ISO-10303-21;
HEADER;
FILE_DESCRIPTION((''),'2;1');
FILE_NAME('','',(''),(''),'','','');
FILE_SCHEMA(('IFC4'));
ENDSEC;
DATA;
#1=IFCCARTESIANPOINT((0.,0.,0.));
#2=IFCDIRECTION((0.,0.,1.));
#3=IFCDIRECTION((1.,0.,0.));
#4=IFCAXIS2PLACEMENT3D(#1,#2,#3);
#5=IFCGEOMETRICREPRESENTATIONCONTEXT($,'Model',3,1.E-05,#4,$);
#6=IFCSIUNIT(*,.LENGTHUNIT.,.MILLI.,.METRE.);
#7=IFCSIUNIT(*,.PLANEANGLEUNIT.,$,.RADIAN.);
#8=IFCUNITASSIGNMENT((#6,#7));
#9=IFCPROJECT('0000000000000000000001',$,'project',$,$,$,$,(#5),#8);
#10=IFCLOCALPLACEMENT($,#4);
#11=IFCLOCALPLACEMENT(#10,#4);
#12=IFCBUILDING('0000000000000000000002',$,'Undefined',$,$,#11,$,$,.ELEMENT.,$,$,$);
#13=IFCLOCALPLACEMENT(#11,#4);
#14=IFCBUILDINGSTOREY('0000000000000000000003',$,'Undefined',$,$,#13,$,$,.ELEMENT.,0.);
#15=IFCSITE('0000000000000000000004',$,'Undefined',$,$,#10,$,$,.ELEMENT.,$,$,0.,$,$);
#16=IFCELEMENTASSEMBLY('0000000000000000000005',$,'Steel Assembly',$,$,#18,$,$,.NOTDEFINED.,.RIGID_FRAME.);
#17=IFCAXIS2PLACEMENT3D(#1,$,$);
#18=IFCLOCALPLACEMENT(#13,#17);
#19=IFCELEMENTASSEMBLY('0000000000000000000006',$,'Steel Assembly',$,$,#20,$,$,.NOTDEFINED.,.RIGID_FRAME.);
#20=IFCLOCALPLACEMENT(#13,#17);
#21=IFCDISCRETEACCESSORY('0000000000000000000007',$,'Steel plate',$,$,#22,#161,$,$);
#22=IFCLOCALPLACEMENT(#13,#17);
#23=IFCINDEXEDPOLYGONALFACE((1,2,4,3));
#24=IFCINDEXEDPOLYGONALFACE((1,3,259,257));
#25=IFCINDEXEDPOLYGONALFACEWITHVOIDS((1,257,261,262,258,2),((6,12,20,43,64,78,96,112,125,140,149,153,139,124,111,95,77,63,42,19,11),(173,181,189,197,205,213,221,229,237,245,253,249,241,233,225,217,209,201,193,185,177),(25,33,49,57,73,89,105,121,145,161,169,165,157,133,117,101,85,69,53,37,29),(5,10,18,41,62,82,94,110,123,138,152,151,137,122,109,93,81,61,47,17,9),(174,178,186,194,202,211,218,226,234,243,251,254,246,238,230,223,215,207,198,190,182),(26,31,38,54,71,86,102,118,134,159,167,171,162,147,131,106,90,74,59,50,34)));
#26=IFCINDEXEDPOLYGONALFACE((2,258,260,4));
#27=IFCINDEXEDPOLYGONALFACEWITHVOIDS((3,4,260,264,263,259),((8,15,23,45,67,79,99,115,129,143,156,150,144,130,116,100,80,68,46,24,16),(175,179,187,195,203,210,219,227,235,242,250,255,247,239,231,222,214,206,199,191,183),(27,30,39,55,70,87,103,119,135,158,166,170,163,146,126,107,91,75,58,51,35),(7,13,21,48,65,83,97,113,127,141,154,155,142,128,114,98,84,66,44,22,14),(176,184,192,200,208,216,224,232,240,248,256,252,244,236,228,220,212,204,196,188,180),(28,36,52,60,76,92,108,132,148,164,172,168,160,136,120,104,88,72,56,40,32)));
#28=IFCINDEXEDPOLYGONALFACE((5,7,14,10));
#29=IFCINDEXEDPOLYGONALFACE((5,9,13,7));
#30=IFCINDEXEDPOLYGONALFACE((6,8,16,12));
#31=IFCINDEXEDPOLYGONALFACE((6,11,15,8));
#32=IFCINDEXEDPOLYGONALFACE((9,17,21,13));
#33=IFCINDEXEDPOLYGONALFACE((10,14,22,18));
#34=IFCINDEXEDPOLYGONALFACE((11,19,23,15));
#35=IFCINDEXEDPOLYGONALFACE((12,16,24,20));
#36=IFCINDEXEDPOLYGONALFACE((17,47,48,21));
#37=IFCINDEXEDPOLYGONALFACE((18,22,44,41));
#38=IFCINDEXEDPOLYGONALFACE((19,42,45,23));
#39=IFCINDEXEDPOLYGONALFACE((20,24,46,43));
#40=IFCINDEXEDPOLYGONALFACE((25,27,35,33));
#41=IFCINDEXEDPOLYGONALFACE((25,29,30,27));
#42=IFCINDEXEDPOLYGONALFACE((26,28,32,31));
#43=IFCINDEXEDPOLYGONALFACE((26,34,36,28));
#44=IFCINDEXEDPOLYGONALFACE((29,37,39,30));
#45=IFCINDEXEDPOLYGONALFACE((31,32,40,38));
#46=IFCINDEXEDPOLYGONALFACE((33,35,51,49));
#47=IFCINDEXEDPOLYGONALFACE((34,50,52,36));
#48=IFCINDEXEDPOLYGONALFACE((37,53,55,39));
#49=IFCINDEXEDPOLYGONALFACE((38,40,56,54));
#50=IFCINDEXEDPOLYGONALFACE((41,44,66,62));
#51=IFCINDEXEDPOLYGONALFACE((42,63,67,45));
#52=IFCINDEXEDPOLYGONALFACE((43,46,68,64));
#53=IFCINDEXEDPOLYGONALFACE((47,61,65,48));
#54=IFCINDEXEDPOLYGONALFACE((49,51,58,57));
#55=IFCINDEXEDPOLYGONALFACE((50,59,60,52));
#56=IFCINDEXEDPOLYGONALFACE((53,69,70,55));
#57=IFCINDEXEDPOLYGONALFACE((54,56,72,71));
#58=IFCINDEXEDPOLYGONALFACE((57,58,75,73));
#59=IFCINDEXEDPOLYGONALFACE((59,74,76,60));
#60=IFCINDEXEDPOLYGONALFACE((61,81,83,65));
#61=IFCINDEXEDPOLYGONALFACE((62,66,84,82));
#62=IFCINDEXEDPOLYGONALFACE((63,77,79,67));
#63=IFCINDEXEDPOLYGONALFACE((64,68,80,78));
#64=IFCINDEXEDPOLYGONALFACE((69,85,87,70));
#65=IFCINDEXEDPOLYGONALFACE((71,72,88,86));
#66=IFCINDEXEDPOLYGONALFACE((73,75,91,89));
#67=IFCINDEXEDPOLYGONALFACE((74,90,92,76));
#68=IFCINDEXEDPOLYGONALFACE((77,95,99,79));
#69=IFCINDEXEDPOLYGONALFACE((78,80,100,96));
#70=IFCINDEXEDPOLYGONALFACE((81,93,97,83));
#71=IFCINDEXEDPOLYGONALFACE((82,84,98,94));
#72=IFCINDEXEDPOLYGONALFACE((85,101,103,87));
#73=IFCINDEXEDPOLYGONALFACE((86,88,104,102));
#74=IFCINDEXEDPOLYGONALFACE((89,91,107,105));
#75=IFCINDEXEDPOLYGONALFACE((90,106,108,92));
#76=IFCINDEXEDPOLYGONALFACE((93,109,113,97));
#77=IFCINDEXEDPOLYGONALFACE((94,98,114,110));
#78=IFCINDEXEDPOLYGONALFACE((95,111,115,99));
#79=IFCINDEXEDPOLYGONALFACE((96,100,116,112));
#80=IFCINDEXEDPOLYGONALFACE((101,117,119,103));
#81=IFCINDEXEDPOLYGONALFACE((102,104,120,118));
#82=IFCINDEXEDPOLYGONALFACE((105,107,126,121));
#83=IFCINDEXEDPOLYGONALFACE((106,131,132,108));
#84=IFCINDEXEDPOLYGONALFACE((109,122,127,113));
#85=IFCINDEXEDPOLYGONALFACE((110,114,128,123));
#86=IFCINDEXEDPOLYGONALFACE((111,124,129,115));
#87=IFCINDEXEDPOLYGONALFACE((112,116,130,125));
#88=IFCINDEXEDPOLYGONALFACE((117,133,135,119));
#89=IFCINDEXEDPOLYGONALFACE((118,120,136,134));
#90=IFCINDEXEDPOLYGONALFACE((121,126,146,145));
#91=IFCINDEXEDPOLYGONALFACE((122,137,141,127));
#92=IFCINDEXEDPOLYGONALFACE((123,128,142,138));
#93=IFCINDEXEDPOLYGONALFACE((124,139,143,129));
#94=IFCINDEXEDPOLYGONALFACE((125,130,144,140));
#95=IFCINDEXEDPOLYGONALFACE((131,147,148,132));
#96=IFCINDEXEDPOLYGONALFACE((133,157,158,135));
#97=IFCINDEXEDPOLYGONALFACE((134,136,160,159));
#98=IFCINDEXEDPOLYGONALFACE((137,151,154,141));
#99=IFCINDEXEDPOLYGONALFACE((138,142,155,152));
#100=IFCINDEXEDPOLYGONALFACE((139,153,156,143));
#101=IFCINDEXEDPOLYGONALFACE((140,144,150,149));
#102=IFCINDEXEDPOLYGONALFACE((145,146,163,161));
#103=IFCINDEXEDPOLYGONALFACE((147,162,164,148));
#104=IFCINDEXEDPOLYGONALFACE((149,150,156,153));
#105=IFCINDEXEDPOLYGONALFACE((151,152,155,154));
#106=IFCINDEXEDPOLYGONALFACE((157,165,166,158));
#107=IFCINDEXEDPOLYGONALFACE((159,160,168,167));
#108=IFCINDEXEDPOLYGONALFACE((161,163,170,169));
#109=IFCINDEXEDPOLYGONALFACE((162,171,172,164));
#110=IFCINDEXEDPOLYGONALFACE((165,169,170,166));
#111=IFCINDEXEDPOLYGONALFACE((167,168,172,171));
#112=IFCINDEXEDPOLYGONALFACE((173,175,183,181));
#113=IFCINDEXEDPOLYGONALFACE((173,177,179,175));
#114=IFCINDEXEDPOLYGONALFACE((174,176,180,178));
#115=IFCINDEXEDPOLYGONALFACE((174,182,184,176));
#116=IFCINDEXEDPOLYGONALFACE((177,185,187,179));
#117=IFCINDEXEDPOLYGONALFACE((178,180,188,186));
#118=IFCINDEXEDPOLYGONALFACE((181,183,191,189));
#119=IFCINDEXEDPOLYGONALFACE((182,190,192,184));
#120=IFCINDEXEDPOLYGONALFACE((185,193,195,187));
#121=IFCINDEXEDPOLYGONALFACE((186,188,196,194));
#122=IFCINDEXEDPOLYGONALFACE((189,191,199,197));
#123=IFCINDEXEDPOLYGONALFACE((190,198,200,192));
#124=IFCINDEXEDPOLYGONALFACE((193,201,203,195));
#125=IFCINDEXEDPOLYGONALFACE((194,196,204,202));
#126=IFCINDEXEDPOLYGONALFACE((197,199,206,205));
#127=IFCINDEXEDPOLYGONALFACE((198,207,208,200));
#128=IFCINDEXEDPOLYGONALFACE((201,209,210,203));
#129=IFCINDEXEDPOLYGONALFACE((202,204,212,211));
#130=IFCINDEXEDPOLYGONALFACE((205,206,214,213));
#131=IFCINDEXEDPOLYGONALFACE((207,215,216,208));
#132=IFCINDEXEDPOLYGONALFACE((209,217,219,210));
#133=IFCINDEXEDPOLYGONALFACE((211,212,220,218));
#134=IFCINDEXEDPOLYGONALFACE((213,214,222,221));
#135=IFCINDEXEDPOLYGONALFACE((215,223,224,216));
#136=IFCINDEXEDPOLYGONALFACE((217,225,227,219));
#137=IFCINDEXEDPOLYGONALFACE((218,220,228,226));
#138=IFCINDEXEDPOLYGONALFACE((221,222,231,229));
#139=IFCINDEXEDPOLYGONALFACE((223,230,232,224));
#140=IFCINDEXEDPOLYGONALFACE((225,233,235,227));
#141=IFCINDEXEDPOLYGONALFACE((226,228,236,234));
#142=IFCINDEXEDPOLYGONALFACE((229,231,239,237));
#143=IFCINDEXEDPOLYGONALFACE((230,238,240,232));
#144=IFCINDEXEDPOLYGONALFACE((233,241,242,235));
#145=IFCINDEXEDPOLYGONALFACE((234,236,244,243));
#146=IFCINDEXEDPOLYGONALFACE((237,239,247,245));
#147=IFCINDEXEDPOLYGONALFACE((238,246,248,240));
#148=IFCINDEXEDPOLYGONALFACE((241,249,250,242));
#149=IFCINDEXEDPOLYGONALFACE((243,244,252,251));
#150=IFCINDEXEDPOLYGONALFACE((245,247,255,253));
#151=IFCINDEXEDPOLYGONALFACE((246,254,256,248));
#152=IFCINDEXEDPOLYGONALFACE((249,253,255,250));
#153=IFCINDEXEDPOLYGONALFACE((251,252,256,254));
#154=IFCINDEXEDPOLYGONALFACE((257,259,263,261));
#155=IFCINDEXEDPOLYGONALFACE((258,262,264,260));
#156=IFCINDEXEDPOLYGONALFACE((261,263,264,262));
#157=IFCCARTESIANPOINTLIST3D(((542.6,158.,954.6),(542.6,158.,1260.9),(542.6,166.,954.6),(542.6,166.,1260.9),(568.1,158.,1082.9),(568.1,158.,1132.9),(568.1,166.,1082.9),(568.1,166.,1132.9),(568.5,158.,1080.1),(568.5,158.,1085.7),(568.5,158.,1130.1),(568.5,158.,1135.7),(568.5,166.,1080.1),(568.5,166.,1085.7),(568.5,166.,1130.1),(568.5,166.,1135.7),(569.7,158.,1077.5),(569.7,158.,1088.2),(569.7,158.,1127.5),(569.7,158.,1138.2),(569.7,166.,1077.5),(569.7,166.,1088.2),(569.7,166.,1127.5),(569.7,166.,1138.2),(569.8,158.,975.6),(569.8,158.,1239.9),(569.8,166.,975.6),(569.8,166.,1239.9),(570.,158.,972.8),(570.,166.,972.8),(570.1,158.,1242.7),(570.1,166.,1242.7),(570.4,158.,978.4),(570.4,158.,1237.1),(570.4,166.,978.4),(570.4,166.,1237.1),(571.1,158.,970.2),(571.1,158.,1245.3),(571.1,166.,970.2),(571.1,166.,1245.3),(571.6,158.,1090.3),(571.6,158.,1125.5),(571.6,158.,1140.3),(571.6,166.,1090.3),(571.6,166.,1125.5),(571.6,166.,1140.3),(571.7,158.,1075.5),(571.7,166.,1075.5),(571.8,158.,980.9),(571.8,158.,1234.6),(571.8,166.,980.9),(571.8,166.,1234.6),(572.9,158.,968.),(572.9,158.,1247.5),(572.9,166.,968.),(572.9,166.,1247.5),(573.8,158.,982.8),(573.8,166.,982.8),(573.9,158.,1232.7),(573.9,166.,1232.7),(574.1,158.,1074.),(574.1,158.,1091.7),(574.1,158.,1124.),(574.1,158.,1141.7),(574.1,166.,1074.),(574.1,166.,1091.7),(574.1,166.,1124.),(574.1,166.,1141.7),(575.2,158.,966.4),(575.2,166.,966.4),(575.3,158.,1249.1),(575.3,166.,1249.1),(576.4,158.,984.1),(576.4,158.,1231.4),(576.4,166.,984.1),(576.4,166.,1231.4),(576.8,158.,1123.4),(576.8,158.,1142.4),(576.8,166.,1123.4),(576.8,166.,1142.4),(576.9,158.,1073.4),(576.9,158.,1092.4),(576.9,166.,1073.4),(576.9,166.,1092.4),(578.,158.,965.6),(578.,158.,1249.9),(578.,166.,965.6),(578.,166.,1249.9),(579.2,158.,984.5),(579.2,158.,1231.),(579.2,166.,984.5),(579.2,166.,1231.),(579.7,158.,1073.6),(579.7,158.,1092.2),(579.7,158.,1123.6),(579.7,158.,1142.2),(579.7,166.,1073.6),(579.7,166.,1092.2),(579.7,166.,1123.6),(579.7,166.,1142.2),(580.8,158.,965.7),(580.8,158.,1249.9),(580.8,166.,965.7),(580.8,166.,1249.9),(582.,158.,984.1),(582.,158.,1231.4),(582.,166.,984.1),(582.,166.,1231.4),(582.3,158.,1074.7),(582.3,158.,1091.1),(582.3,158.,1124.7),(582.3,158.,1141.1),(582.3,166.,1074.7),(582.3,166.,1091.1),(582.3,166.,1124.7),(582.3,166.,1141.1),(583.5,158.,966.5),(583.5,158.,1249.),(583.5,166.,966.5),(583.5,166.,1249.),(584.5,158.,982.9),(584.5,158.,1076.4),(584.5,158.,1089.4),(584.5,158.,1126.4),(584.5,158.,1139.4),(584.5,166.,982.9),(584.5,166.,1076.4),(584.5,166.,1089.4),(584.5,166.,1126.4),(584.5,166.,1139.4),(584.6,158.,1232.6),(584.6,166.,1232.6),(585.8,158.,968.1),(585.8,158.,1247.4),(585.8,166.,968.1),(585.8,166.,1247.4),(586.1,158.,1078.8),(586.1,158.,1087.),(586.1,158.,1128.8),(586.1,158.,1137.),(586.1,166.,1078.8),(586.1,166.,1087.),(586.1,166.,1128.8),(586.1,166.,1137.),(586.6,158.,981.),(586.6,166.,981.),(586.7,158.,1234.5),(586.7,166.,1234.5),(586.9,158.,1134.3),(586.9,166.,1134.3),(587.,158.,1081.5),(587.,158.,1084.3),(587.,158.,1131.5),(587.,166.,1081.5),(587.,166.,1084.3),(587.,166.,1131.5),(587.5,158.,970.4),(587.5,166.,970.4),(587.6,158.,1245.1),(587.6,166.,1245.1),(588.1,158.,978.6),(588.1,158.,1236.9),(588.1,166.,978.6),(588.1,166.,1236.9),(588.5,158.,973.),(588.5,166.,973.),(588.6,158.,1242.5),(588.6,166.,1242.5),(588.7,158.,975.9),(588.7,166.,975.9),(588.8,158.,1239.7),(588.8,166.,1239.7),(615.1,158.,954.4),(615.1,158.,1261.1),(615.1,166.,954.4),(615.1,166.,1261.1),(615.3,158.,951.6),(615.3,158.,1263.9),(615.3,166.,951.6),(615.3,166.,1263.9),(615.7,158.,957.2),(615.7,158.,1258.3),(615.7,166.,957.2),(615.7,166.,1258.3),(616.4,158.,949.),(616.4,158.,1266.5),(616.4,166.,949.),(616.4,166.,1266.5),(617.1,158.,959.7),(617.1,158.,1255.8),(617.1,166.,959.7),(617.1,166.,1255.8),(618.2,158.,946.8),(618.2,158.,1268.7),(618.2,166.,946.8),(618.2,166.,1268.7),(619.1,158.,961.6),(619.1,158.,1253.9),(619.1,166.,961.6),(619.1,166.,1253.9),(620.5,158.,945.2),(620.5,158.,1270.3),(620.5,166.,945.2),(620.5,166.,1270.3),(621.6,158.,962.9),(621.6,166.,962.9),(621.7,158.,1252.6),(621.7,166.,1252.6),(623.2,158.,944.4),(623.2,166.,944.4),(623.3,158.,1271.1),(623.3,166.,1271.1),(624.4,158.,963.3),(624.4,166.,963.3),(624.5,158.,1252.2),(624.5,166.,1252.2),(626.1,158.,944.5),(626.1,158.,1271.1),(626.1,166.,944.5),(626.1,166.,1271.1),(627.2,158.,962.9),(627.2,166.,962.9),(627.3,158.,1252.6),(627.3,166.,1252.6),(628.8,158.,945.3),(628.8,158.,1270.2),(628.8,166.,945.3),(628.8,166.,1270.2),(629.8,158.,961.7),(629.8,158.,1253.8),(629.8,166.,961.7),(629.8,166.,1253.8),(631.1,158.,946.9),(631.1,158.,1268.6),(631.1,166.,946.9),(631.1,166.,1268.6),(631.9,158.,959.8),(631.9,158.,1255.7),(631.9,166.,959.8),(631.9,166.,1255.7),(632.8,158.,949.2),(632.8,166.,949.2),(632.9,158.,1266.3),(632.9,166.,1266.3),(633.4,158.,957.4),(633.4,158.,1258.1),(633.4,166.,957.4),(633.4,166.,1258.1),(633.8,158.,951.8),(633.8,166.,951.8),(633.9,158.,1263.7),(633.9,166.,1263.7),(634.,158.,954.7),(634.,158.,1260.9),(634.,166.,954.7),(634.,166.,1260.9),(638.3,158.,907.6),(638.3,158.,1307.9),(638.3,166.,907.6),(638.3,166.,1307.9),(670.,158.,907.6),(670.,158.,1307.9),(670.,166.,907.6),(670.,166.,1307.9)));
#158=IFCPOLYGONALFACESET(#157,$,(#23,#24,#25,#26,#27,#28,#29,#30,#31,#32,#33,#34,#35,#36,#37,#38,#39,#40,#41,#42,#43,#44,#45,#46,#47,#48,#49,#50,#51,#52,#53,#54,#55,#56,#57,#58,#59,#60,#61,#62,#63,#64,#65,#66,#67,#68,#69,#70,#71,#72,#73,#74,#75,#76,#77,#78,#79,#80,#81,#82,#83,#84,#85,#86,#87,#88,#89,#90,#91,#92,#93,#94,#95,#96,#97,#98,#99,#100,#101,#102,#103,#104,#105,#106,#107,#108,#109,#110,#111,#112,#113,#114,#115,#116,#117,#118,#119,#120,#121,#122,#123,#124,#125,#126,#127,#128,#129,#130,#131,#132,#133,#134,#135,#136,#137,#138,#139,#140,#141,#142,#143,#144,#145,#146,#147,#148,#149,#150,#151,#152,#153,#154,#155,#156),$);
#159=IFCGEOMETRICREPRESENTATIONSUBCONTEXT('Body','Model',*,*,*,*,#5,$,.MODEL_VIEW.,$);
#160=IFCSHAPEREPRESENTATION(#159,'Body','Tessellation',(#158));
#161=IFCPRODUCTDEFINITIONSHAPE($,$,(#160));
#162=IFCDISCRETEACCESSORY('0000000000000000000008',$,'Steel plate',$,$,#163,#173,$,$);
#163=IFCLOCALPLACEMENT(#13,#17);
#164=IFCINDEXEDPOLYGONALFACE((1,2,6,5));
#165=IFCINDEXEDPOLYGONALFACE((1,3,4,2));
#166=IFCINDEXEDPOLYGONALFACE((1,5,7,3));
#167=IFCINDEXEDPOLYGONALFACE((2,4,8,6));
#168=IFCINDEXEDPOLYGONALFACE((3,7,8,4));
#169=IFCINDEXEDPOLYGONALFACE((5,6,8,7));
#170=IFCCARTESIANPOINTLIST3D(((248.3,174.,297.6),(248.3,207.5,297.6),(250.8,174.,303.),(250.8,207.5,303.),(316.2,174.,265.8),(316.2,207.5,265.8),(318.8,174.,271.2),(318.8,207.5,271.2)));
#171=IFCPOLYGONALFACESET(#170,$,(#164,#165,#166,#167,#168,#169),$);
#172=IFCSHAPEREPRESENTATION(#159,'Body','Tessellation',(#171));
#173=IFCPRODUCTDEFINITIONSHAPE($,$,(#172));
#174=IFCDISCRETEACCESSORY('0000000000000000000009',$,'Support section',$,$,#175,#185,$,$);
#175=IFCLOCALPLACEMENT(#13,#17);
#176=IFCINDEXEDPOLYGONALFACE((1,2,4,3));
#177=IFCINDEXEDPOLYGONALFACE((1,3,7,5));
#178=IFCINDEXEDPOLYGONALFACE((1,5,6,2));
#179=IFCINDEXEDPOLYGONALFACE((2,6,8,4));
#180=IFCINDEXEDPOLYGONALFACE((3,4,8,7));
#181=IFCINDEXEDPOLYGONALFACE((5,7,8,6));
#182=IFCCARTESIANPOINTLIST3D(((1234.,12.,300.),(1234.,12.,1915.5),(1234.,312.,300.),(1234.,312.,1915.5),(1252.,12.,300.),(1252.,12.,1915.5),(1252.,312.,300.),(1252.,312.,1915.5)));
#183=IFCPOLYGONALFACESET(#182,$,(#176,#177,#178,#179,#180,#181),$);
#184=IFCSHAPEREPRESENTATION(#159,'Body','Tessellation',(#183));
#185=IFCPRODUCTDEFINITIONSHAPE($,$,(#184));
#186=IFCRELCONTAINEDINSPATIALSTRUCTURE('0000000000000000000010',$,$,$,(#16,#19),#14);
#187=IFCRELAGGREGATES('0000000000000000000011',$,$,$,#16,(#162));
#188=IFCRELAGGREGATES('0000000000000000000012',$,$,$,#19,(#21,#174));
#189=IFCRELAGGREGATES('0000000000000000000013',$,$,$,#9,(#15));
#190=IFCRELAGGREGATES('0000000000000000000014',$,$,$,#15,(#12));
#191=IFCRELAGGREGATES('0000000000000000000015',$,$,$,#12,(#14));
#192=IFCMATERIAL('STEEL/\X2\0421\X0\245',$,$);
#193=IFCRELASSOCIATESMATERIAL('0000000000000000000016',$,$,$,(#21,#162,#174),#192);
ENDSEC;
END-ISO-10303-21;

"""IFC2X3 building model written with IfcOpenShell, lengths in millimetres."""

from ifc_helpers import new_model, si_unit, frame, origin_with_axes, origin_2d_with_axis, place, context, subcontext, project, spatial, polyline, rectangle, circle, outline, extrude, source, transform, mapped, material, element, aggregate, save


model = new_model("IFC2X3")

# Units and contexts
model_context = context("Model", 3, precision=1e-05, world=origin_with_axes())
body_context = subcontext(model_context, "Body", "Model", "MODEL_VIEW")
ifc_project = project(units=[si_unit("LENGTHUNIT", "METRE", prefix="MILLI"), si_unit("PLANEANGLEUNIT", "RADIAN")], contexts=[model_context])

# Site, building, storey
site_placement = place(None, origin_with_axes())
site = spatial("IfcSite", under=ifc_project, at=site_placement, Name="Undefined", CompositionType="ELEMENT", RefElevation=0.0)
building_placement = place(site_placement, origin_with_axes())
building = spatial("IfcBuilding", under=site, at=building_placement, Name="Undefined", CompositionType="ELEMENT")
storey_placement = place(building_placement, origin_with_axes())
storey = spatial("IfcBuildingStorey", under=building, at=storey_placement, Name="Undefined", CompositionType="ELEMENT", Elevation=0.0)

# Element assembly
assembly_1_placement = place(storey_placement, origin_with_axes())
assembly_1 = element("IfcElementAssembly", 1, at=assembly_1_placement, inside=storey, Name="Steel Assembly", AssemblyPlace="NOTDEFINED", PredefinedType="RIGID_FRAME")

# Shared definitions
ifc_material_1 = material(Name="STEEL/С245")

# Element assembly, discrete accessory, openings
assembly_2_placement = place(storey_placement, origin_with_axes())
assembly_2 = element("IfcElementAssembly", 2, at=assembly_2_placement, inside=storey, Name="Steel Assembly", AssemblyPlace="NOTDEFINED", PredefinedType="RIGID_FRAME")
discrete_accessory_1_placement = place(assembly_2_placement, frame((670.0, 162.0, 907.6), z_axis=(0.0, 1.0, 0.0), x_axis=(-1.0, 0.0, 0.0)))
discrete_accessory_1 = element("IfcDiscreteAccessory", 3, at=discrete_accessory_1_placement, material=ifc_material_1, Name="Steel plate", context=body_context, shape_type="SweptSolid", body=[
    extrude(outline(polyline([(0.0, 0.0), (31.7, 0.0), (127.4, 47.0), (127.4, 353.4), (31.7, 400.3), (0.0, 400.3), (0.0, 0.0)])), frame((0.0, 0.0, -4.0), z_axis=(0.0, 0.0, 1.0), x_axis=(1.0, 0.0, 0.0)), (0.0, 0.0, 1.0), 8.0),
])
shared_shape_1 = source(origin_with_axes(), body_context, "Body", "SweptSolid", [
    extrude(circle(Radius=9.5, at=origin_2d_with_axis()), frame((0.0, 3.9, 0.0), z_axis=(0.0, 1.0, 0.0), x_axis=(1.0, 0.0, 0.0)), (0.0, 0.0, 1.0), 12.1),
])
opening_1_placement = place(assembly_2_placement, frame((601.9, 170.0, 1251.1), z_axis=(0.905659, 0.0, 0.424008), x_axis=(-0.424008, 0.0, 0.905659)))
element("IfcOpeningElement", 4, at=opening_1_placement, cuts=discrete_accessory_1, ObjectType="Opening", context=body_context, shape_type="MappedRepresentation", body=[
    mapped(shared_shape_1, transform((0.0, 0.0, -25.0))),
    mapped(shared_shape_1, transform((0.0, 0.0, 25.0))),
])
opening_2_placement = place(assembly_2_placement, frame((577.6, 170.0, 1107.9), z_axis=(-0.000373, 0.0, 1.0), x_axis=(-1.0, 0.0, -0.000373)))
element("IfcOpeningElement", 5, at=opening_2_placement, cuts=discrete_accessory_1, ObjectType="Opening", context=body_context, shape_type="MappedRepresentation", body=[
    mapped(shared_shape_1, transform((0.0, 0.0, -25.0))),
    mapped(shared_shape_1, transform((0.0, 0.0, 25.0))),
])
shared_shape_2 = source(origin_with_axes(), body_context, "Body", "SweptSolid", [
    extrude(circle(Radius=9.5, at=origin_2d_with_axis()), frame((0.0, -12.1, 0.0), z_axis=(0.0, 1.0, 0.0), x_axis=(1.0, 0.0, 0.0)), (0.0, 0.0, 1.0), 20.3),
])
opening_3_placement = place(assembly_2_placement, frame((601.9, 170.0, 964.4), z_axis=(0.905659, 0.0, -0.424008), x_axis=(-0.424008, 0.0, -0.905659)))
element("IfcOpeningElement", 6, at=opening_3_placement, cuts=discrete_accessory_1, ObjectType="Opening", context=body_context, shape_type="MappedRepresentation", body=[
    mapped(shared_shape_2, transform((0.0, 0.0, -25.0))),
    mapped(shared_shape_2, transform((0.0, 0.0, 25.0))),
])

# Discrete accessory, opening
discrete_accessory_2_placement = place(assembly_1_placement, frame((317.5, 207.5, 268.5), z_axis=(0.424008, 0.0, 0.905659), x_axis=(-0.905659, 0.0, 0.424008)))
discrete_accessory_2 = element("IfcDiscreteAccessory", 7, at=discrete_accessory_2_placement, material=ifc_material_1, Name="Steel plate", context=body_context, shape_type="SweptSolid", body=[
    extrude(outline(polyline([(0.0, 0.0), (75.0, 0.0), (75.0, 75.0), (0.0, 75.0), (0.0, 0.0)])), frame((0.0, 0.0, -3.0), z_axis=(0.0, 0.0, 1.0), x_axis=(1.0, 0.0, 0.0)), (0.0, 0.0, 1.0), 6.0),
])
opening_4_placement = place(assembly_1_placement, frame((317.5, 207.5, 268.5), z_axis=(0.424008, 0.0, 0.905659), x_axis=(-0.905659, 0.0, 0.424008)))
element("IfcOpeningElement", 8, at=opening_4_placement, cuts=discrete_accessory_2, ObjectType="Recess", context=body_context, shape_type="SweptSolid", body=[
    extrude(outline(polyline([(0.0, 0.0), (75.0, 0.0), (75.0, 150.0), (0.0, 150.0), (0.0, 0.0)])), frame((-37.5, 108.5, -6.0), z_axis=(0.0, 0.0, 1.0), x_axis=(0.0, -1.0, 0.0)), (0.0, 0.0, 1.0), 12.0),
])
aggregate(assembly_1, [discrete_accessory_2])

# Discrete accessory
discrete_accessory_3_placement = place(assembly_2_placement, frame((1243.0, 162.0, 300.0), z_axis=(0.0, 0.0, 1.0), x_axis=(1.0, 0.0, 0.0)))
discrete_accessory_3 = element("IfcDiscreteAccessory", 9, at=discrete_accessory_3_placement, material=ifc_material_1, Name="Support section", context=body_context, shape_type="SweptSolid", body=[
    extrude(rectangle(XDim=18.0, YDim=300.0, at=origin_2d_with_axis()), frame((0.0, 0.0, 1615.5), z_axis=(0.0, 0.0, -1.0), x_axis=(-1.0, 0.0, 0.0)), (0.0, 0.0, 1.0), 1615.5),
])
aggregate(assembly_2, [discrete_accessory_1, discrete_accessory_3])

save(model, "model.ifc")
